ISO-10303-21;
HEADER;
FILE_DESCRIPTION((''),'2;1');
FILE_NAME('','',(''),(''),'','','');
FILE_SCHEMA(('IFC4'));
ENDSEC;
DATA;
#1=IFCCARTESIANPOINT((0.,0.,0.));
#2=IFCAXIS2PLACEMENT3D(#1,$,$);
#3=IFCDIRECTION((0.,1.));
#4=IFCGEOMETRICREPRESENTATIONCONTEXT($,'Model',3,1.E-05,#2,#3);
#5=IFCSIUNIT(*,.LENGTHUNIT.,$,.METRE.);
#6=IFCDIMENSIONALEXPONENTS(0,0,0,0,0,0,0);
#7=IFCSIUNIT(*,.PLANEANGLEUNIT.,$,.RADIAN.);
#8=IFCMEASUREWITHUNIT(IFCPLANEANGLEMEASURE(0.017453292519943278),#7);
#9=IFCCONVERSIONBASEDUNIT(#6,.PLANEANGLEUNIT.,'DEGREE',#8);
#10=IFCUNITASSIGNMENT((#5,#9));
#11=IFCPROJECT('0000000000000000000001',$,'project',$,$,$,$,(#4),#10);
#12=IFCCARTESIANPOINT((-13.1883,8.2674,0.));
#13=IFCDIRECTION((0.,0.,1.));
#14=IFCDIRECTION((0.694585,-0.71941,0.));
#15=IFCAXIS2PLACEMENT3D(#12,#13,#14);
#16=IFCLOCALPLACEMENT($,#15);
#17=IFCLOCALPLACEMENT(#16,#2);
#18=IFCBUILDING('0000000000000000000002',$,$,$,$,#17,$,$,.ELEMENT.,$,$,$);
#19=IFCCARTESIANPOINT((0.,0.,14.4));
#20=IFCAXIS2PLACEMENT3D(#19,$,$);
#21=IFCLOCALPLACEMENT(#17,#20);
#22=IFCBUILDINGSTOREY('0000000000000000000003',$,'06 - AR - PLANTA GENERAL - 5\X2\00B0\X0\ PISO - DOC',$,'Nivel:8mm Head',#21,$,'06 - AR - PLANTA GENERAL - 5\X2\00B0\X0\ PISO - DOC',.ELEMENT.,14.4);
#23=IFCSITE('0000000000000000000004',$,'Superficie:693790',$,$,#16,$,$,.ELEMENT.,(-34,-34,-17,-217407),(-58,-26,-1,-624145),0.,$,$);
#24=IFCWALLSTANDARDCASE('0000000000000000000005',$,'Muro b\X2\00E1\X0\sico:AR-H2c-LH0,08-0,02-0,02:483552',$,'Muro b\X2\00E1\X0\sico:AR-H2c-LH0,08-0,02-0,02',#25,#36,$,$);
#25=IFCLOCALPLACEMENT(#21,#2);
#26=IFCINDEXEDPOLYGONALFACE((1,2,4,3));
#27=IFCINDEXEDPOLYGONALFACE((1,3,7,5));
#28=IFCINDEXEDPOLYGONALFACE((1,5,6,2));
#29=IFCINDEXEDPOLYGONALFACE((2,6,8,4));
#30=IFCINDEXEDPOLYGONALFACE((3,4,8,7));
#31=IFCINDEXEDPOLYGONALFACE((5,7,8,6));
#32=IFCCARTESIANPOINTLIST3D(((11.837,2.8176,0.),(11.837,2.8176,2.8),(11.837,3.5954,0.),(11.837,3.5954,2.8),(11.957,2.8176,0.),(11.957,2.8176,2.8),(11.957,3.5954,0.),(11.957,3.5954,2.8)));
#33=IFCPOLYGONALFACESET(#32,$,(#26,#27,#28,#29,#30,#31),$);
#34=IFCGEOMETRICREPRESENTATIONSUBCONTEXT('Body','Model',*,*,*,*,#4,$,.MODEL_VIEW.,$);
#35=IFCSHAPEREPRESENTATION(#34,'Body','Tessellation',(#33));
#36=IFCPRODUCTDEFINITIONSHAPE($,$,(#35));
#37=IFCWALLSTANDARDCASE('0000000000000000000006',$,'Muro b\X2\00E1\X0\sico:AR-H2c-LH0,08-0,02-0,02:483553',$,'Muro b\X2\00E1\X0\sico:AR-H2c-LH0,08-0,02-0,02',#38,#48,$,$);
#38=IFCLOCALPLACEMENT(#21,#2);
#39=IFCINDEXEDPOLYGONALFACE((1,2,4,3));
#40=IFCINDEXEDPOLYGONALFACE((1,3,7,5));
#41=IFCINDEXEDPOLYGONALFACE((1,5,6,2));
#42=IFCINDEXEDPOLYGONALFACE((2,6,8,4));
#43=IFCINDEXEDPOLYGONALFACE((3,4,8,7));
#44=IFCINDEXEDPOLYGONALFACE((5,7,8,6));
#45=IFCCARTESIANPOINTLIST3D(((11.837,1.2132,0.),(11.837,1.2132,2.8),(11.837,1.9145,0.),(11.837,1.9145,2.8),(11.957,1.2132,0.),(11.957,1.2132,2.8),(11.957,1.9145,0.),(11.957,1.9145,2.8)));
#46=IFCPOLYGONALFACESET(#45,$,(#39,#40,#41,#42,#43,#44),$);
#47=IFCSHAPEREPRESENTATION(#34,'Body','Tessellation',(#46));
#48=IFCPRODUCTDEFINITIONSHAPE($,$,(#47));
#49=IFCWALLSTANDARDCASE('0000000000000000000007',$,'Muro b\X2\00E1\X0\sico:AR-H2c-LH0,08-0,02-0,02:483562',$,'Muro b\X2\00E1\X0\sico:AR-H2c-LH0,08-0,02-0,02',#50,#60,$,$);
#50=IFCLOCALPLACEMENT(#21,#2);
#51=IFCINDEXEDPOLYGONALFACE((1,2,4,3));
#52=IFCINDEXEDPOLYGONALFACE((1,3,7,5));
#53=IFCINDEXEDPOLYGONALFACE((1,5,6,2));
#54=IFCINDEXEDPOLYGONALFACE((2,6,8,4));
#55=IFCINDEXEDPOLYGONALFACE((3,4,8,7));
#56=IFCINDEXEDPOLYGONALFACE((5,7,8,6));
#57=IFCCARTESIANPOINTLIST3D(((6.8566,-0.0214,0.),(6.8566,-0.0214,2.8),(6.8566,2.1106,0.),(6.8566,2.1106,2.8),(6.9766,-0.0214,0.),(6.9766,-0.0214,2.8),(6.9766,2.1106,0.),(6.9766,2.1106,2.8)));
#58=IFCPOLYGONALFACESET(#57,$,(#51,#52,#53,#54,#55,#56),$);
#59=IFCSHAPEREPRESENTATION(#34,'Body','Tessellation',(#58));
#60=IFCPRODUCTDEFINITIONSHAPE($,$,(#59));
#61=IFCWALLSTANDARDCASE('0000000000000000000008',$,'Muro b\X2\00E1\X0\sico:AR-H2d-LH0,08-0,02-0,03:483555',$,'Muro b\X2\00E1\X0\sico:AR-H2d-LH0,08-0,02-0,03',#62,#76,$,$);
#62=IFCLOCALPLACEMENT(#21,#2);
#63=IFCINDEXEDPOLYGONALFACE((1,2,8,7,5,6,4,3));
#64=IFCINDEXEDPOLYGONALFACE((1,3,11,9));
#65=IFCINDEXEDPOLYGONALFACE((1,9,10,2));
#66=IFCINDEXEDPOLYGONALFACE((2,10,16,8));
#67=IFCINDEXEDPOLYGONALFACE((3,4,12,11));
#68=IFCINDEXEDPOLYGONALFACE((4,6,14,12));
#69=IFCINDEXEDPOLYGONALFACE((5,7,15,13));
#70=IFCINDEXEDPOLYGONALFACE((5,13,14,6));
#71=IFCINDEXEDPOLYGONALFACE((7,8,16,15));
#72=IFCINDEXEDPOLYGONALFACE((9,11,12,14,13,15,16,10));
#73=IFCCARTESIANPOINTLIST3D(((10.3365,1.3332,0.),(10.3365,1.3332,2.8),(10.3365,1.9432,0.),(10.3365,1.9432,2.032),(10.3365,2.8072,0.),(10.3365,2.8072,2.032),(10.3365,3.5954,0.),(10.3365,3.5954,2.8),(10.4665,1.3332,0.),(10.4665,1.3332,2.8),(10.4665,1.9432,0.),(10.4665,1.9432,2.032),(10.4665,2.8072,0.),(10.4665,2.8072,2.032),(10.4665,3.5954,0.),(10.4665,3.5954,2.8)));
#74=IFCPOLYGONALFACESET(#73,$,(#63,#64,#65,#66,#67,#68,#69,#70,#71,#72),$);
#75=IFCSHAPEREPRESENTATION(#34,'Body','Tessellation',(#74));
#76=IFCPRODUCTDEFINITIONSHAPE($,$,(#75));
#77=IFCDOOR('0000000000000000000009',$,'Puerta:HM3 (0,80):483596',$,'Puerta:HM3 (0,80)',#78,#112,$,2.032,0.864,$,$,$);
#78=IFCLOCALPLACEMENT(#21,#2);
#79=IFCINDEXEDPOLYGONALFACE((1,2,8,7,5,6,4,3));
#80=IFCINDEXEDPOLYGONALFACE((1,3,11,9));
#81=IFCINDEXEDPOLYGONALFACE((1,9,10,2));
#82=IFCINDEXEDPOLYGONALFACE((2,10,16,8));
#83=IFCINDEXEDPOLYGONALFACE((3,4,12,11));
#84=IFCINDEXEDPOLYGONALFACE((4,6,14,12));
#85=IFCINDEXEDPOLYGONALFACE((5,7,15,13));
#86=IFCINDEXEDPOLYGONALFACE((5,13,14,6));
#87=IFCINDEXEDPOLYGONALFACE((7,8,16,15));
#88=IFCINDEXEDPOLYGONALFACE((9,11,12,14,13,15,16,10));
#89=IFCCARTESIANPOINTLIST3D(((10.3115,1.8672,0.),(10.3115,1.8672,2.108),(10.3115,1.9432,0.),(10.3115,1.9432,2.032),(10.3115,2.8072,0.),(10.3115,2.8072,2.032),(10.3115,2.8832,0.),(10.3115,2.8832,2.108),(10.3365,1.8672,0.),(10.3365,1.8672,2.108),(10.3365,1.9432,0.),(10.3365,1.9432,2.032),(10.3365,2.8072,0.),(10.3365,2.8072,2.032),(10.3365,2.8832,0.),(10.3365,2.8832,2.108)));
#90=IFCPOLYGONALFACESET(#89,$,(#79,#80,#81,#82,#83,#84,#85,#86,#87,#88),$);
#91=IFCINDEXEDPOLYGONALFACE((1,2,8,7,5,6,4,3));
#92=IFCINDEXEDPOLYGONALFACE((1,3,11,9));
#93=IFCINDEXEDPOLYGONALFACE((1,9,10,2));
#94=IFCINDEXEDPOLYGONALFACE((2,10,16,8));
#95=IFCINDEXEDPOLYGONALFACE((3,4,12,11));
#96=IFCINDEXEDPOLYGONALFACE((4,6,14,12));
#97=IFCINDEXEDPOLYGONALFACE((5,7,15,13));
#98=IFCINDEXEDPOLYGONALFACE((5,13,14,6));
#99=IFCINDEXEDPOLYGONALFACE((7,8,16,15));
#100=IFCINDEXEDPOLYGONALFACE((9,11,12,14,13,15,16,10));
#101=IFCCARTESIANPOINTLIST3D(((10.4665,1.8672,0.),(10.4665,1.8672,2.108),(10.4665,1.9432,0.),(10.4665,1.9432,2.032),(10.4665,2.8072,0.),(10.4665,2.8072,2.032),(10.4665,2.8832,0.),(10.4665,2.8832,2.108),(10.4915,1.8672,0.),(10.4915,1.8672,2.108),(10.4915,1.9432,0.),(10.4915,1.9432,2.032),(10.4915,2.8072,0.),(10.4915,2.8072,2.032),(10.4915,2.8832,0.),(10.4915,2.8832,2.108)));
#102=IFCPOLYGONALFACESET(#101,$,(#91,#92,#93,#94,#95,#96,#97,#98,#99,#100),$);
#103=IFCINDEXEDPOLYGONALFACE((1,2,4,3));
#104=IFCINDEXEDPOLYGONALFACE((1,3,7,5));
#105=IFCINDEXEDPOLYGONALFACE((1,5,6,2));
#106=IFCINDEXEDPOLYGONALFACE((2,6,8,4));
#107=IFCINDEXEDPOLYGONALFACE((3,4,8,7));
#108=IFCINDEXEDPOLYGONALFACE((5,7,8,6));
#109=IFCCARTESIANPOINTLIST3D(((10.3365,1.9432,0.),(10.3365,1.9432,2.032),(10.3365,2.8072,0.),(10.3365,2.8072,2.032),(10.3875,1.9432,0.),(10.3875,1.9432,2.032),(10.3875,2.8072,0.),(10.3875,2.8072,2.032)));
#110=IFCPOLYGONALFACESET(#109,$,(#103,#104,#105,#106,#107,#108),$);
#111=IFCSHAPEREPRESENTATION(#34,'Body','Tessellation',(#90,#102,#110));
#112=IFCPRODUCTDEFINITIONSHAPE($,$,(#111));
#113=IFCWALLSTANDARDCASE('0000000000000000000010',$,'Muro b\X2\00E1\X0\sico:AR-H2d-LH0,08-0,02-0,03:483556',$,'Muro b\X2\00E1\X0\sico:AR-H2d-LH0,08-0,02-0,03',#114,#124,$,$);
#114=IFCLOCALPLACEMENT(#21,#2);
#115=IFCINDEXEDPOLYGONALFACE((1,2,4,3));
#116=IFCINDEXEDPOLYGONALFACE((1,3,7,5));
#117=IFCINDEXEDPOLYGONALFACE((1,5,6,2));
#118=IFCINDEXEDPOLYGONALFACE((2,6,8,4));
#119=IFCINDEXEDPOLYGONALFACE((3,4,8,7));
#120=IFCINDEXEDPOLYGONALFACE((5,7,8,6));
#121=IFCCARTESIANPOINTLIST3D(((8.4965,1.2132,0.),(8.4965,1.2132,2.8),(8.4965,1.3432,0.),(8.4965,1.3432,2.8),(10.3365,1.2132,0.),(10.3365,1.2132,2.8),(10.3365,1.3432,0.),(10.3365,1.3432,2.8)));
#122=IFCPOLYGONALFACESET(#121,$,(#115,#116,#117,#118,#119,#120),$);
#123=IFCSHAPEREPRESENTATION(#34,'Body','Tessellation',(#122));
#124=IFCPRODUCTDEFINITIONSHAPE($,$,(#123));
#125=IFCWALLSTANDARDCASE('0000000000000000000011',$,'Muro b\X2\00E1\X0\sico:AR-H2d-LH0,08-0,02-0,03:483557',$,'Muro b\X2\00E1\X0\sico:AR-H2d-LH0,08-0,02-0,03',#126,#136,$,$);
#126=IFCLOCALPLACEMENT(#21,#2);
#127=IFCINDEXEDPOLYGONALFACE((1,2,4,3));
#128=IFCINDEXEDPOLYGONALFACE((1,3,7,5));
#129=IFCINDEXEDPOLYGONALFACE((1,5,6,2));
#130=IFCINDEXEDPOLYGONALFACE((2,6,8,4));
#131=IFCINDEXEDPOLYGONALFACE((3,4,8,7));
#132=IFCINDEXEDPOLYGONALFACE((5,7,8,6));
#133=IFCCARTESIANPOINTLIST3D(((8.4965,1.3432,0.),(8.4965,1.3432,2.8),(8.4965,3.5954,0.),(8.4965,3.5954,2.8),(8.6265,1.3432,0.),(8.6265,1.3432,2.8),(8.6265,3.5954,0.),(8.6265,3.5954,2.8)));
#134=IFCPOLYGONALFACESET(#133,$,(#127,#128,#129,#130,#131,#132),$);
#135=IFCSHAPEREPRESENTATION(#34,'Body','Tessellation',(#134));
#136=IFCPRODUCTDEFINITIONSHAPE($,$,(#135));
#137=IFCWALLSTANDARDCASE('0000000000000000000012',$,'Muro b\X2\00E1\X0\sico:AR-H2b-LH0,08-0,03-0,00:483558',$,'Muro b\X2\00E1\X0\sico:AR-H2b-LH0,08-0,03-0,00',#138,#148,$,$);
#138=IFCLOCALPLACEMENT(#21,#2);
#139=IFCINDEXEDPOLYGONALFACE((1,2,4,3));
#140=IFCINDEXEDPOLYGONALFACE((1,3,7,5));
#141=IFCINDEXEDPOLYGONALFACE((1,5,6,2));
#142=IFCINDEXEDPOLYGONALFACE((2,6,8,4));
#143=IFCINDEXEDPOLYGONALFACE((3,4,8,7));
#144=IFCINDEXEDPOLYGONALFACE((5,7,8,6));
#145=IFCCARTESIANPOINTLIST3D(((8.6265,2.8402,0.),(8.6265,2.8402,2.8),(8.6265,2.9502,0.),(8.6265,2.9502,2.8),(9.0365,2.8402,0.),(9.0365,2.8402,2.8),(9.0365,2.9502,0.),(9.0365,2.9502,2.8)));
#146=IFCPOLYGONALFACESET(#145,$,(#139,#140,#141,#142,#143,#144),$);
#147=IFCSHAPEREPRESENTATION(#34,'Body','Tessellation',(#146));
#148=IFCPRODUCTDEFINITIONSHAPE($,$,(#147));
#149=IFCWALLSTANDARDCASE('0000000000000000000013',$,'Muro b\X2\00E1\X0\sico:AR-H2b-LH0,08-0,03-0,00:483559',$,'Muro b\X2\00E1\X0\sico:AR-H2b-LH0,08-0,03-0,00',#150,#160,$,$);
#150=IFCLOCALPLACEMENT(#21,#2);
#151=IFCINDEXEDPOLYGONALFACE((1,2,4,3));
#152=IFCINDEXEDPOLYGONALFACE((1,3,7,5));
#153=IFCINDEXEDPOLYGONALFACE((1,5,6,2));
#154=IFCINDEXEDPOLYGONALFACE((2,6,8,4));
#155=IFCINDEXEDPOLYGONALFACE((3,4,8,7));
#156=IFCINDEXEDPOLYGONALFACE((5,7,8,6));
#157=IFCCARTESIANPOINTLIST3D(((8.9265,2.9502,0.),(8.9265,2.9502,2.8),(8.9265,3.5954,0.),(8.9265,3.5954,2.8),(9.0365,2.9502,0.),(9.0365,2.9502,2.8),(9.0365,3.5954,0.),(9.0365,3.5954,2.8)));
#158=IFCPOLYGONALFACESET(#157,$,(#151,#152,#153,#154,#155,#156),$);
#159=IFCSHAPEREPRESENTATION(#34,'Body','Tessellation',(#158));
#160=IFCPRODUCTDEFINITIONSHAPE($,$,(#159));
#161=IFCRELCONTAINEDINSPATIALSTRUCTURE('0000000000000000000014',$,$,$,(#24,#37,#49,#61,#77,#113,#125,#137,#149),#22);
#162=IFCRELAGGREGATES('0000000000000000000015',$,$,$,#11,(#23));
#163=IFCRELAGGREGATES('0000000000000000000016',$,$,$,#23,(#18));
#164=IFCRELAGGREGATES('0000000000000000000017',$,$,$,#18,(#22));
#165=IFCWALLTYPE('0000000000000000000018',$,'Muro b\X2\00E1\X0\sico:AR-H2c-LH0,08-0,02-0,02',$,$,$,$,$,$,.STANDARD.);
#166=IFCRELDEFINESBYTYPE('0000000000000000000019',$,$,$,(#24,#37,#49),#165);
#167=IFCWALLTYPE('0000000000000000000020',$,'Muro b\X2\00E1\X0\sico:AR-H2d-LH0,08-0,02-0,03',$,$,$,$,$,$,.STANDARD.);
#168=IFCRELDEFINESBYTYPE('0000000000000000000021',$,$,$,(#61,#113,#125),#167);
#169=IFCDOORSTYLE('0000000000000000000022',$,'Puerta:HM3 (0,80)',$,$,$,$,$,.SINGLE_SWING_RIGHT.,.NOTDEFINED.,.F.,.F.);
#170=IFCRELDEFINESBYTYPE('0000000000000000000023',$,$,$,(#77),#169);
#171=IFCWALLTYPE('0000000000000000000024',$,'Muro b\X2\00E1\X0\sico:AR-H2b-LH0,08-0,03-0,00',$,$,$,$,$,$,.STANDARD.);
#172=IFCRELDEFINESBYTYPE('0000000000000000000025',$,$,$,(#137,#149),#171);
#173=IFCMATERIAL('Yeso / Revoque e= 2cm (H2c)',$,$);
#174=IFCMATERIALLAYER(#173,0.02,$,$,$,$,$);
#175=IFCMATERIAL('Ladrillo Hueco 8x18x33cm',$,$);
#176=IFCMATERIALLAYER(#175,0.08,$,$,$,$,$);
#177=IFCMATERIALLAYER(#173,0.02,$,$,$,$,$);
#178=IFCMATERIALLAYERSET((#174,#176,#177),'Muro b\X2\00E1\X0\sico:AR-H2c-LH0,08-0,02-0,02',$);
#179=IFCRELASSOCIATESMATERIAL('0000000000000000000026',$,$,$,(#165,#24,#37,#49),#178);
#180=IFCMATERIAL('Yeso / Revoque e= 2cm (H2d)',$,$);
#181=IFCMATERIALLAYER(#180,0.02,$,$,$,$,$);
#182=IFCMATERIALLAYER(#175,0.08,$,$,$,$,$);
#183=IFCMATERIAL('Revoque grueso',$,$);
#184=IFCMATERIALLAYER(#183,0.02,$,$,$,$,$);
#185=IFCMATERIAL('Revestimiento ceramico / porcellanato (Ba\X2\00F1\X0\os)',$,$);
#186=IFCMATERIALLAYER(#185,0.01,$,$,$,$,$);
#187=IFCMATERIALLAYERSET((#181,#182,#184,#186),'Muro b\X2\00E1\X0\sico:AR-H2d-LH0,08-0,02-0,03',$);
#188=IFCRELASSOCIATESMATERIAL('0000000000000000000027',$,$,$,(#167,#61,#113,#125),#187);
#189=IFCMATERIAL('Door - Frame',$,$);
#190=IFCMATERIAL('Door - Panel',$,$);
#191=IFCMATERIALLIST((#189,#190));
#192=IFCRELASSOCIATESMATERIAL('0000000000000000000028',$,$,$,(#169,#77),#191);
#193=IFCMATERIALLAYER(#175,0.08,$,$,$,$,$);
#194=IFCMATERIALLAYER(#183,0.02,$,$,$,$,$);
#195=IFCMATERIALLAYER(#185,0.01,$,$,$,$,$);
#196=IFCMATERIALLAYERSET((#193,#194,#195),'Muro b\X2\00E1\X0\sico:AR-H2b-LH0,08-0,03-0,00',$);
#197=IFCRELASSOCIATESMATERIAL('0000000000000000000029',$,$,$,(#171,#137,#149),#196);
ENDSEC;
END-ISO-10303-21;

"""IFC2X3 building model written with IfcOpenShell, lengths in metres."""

from ifc_helpers import new_model, entity, si_unit, converted_unit, direction, frame, frame_2d, origin, place, context, subcontext, project, spatial, polyline, rectangle, outline, extrude, source, transform, mapped, material, material_list, layer, layer_set, layer_usage, type_object, type_shapes, element, fill, save


model = new_model("IFC2X3")

# Units and contexts
model_context = context("Model", 3, precision=1e-05, world=origin(), true_north=direction((0.0, 1.0)))
body_context = subcontext(model_context, "Body", "Model", "MODEL_VIEW")
ifc_project = project(units=[si_unit("LENGTHUNIT", "METRE"), converted_unit("PLANEANGLEUNIT", "DEGREE", entity("IfcPlaneAngleMeasure", 0.017453292519943278), si_unit("PLANEANGLEUNIT", "RADIAN"), dimensions=[0, 0, 0, 0, 0, 0, 0])], contexts=[model_context])

# Site, building, storey
site_placement = place(None, frame((-13.1883, 8.2674, 0.0), z_axis=(0.0, 0.0, 1.0), x_axis=(0.694585, -0.71941, 0.0)))
site = spatial("IfcSite", under=ifc_project, at=site_placement, Name="Superficie:693790", CompositionType="ELEMENT", RefLatitude=(-34, -34, -17, -217407), RefLongitude=(-58, -26, -1, -624145), RefElevation=0.0)
building_placement = place(site_placement, origin())
building = spatial("IfcBuilding", under=site, at=building_placement, CompositionType="ELEMENT")
storey_placement = place(building_placement, frame((0.0, 0.0, 14.4)))
storey = spatial("IfcBuildingStorey", under=building, at=storey_placement, Name="06 - AR - PLANTA GENERAL - 5° PISO - DOC", ObjectType="Nivel:8mm Head", LongName="06 - AR - PLANTA GENERAL - 5° PISO - DOC", CompositionType="ELEMENT", Elevation=14.4)

# Walls
ifc_material_1 = material(Name="Yeso / Revoque e= 2cm (H2c)")
ifc_layer_1 = layer(ifc_material_1, 0.02)
ifc_material_2 = material(Name="Ladrillo Hueco 8x18x33cm")
ifc_layer_2 = layer(ifc_material_2, 0.08)
ifc_layer_3 = layer(ifc_material_1, 0.02)
ifc_layer_set_1 = layer_set([ifc_layer_1, ifc_layer_2, ifc_layer_3], Name="Muro básico:AR-H2c-LH0,08-0,02-0,02")
ifc_layer_usage_1 = layer_usage(ifc_layer_set_1, "AXIS2", "NEGATIVE", 0.06)
wall_type_1 = type_object("IfcWallType", Name="Muro básico:AR-H2c-LH0,08-0,02-0,02", PredefinedType="STANDARD", material=ifc_layer_set_1)
wall_1_placement = place(storey_placement, frame((11.897, 3.5954, 0.0), z_axis=(0.0, 0.0, 1.0), x_axis=(0.0, -1.0, 0.0)))
element("IfcWallStandardCase", 1, at=wall_1_placement, inside=storey, type_object=wall_type_1, material=ifc_layer_usage_1, Name="Muro básico:AR-H2c-LH0,08-0,02-0,02:483552", ObjectType="Muro básico:AR-H2c-LH0,08-0,02-0,02", context=body_context, shape_type="SweptSolid", body=[
    extrude(rectangle(XDim=0.7779, YDim=0.12, at=frame_2d((0.3889, 0.0), x_axis=(-1.0, 0.0))), origin(), (0.0, 0.0, 1.0), 2.8),
])
ifc_layer_usage_2 = layer_usage(ifc_layer_set_1, "AXIS2", "NEGATIVE", 0.06)
wall_2_placement = place(storey_placement, frame((11.897, 1.9145, 0.0), z_axis=(0.0, 0.0, 1.0), x_axis=(0.0, -1.0, 0.0)))
element("IfcWallStandardCase", 2, at=wall_2_placement, inside=storey, type_object=wall_type_1, material=ifc_layer_usage_2, Name="Muro básico:AR-H2c-LH0,08-0,02-0,02:483553", ObjectType="Muro básico:AR-H2c-LH0,08-0,02-0,02", context=body_context, shape_type="SweptSolid", body=[
    extrude(rectangle(XDim=0.7014, YDim=0.12, at=frame_2d((0.3507, 0.0), x_axis=(-1.0, 0.0))), origin(), (0.0, 0.0, 1.0), 2.8),
])
ifc_layer_usage_3 = layer_usage(ifc_layer_set_1, "AXIS2", "NEGATIVE", 0.06)
wall_3_placement = place(storey_placement, frame((6.9166, 2.1106, 0.0), z_axis=(0.0, 0.0, 1.0), x_axis=(0.0, -1.0, 0.0)))
element("IfcWallStandardCase", 3, at=wall_3_placement, inside=storey, type_object=wall_type_1, material=ifc_layer_usage_3, Name="Muro básico:AR-H2c-LH0,08-0,02-0,02:483562", ObjectType="Muro básico:AR-H2c-LH0,08-0,02-0,02", context=body_context, shape_type="SweptSolid", body=[
    extrude(rectangle(XDim=2.132, YDim=0.12, at=frame_2d((1.066, 0.0), x_axis=(-1.0, 0.0))), origin(), (0.0, 0.0, 1.0), 2.8),
])

# Wall, opening, door
ifc_material_3 = material(Name="Yeso / Revoque e= 2cm (H2d)")
ifc_layer_4 = layer(ifc_material_3, 0.02)
ifc_layer_5 = layer(ifc_material_2, 0.08)
ifc_material_4 = material(Name="Revoque grueso")
ifc_layer_6 = layer(ifc_material_4, 0.02)
ifc_material_5 = material(Name="Revestimiento ceramico / porcellanato (Baños)")
ifc_layer_7 = layer(ifc_material_5, 0.01)
ifc_layer_set_2 = layer_set([ifc_layer_4, ifc_layer_5, ifc_layer_6, ifc_layer_7], Name="Muro básico:AR-H2d-LH0,08-0,02-0,03")
ifc_layer_usage_4 = layer_usage(ifc_layer_set_2, "AXIS2", "POSITIVE", -0.065)
wall_type_2 = type_object("IfcWallType", Name="Muro básico:AR-H2d-LH0,08-0,02-0,03", PredefinedType="STANDARD", material=ifc_layer_set_2)
wall_4_placement = place(storey_placement, frame((10.4015, 1.3332, 0.0), z_axis=(0.0, 0.0, 1.0), x_axis=(0.0, 1.0, 0.0)))
wall_4 = element("IfcWallStandardCase", 4, at=wall_4_placement, inside=storey, type_object=wall_type_2, material=ifc_layer_usage_4, Name="Muro básico:AR-H2d-LH0,08-0,02-0,03:483555", ObjectType="Muro básico:AR-H2d-LH0,08-0,02-0,03", context=body_context, shape_type="SweptSolid", body=[
    extrude(rectangle(XDim=2.2623, YDim=0.13, at=frame_2d((1.1311, 0.0), x_axis=(-1.0, 0.0))), origin(), (0.0, 0.0, 1.0), 2.8),
])
opening_1_placement = place(wall_4_placement, frame((0.61, -0.065, 0.0)))
opening_1 = element("IfcOpeningElement", 5, at=opening_1_placement, cuts=wall_4, ObjectType="Opening", context=body_context, shape_type="SweptSolid", body=[
    extrude(rectangle(XDim=0.864, YDim=2.032, at=frame_2d((1.016, 0.432), x_axis=(0.0, 1.0))), frame((0.0, 0.0, 0.0), z_axis=(0.0, 1.0, 0.0), x_axis=(0.0, 0.0, 1.0)), (0.0, 0.0, 1.0), 0.13),
])
ifc_material_6 = material(Name="Door - Frame")
ifc_material_7 = material(Name="Door - Panel")
ifc_material_list = material_list([ifc_material_6, ifc_material_7])
door_style_1 = type_object("IfcDoorStyle", Name="Puerta:HM3 (0,80)", ConstructionType="NOTDEFINED", OperationType="SINGLE_SWING_RIGHT", ParameterTakesPrecedence=False, Sizeable=False, material=ifc_material_list)
shared_shape_1 = source(origin(), body_context, "Body", "SweptSolid", [
    extrude(outline(polyline([(-0.508, -1.073), (0.508, -1.073), (0.508, 1.035), (0.432, 1.035), (0.432, -0.997), (-0.432, -0.997), (-0.432, 1.035), (-0.508, 1.035), (-0.508, -1.073)])), frame((0.432, 0.13, 1.035), z_axis=(0.0, 1.0, 0.0), x_axis=(1.0, 0.0, 0.0)), (0.0, 0.0, 1.0), 0.025),
    extrude(outline(polyline([(-1.073, -0.508), (1.035, -0.508), (1.035, -0.432), (-0.997, -0.432), (-0.997, 0.432), (1.035, 0.432), (1.035, 0.508), (-1.073, 0.508), (-1.073, -0.508)])), frame((0.432, -0.025, 1.035), z_axis=(0.0, 1.0, 0.0), x_axis=(0.0, 0.0, -1.0)), (0.0, 0.0, 1.0), 0.025),
    extrude(rectangle(XDim=0.051, YDim=0.864, at=frame_2d((0.0, 0.0), x_axis=(1.0, 0.0))), frame((0.432, 0.1045, 0.0), z_axis=(0.0, 0.0, 1.0), x_axis=(0.0, 1.0, 0.0)), (0.0, 0.0, 1.0), 2.032),
])
type_shapes(door_style_1, [shared_shape_1])
door_1_placement = place(opening_1_placement, origin())
door_1 = element("IfcDoor", 6, at=door_1_placement, inside=storey, type_object=door_style_1, material=ifc_material_list, Name="Puerta:HM3 (0,80):483596", ObjectType="Puerta:HM3 (0,80)", OverallHeight=2.032, OverallWidth=0.864, context=body_context, shape_type="MappedRepresentation", body=[
    mapped(shared_shape_1, transform((0.0, 0.0, 0.0), scale=1.0)),
])
fill(opening_1, door_1)

# Walls
ifc_layer_usage_5 = layer_usage(ifc_layer_set_2, "AXIS2", "NEGATIVE", 0.065)
wall_5_placement = place(storey_placement, frame((10.3365, 1.2782, 0.0), z_axis=(0.0, 0.0, 1.0), x_axis=(-1.0, 0.0, 0.0)))
element("IfcWallStandardCase", 7, at=wall_5_placement, inside=storey, type_object=wall_type_2, material=ifc_layer_usage_5, Name="Muro básico:AR-H2d-LH0,08-0,02-0,03:483556", ObjectType="Muro básico:AR-H2d-LH0,08-0,02-0,03", context=body_context, shape_type="SweptSolid", body=[
    extrude(rectangle(XDim=1.84, YDim=0.13, at=frame_2d((0.92, 0.0), x_axis=(-1.0, 0.0))), origin(), (0.0, 0.0, 1.0), 2.8),
])
ifc_layer_usage_6 = layer_usage(ifc_layer_set_2, "AXIS2", "NEGATIVE", 0.065)
wall_6_placement = place(storey_placement, frame((8.5615, 1.3432, 0.0), z_axis=(0.0, 0.0, 1.0), x_axis=(0.0, 1.0, 0.0)))
element("IfcWallStandardCase", 8, at=wall_6_placement, inside=storey, type_object=wall_type_2, material=ifc_layer_usage_6, Name="Muro básico:AR-H2d-LH0,08-0,02-0,03:483557", ObjectType="Muro básico:AR-H2d-LH0,08-0,02-0,03", context=body_context, shape_type="SweptSolid", body=[
    extrude(rectangle(XDim=2.2523, YDim=0.13, at=frame_2d((1.1261, 0.0), x_axis=(-1.0, 0.0))), origin(), (0.0, 0.0, 1.0), 2.8),
])
ifc_layer_8 = layer(ifc_material_2, 0.08)
ifc_layer_9 = layer(ifc_material_4, 0.02)
ifc_layer_10 = layer(ifc_material_5, 0.01)
ifc_layer_set_3 = layer_set([ifc_layer_8, ifc_layer_9, ifc_layer_10], Name="Muro básico:AR-H2b-LH0,08-0,03-0,00")
ifc_layer_usage_7 = layer_usage(ifc_layer_set_3, "AXIS2", "NEGATIVE", 0.055)
wall_type_3 = type_object("IfcWallType", Name="Muro básico:AR-H2b-LH0,08-0,03-0,00", PredefinedType="STANDARD", material=ifc_layer_set_3)
wall_7_placement = place(storey_placement, frame((8.6265, 2.8952, 0.0)))
element("IfcWallStandardCase", 9, at=wall_7_placement, inside=storey, type_object=wall_type_3, material=ifc_layer_usage_7, Name="Muro básico:AR-H2b-LH0,08-0,03-0,00:483558", ObjectType="Muro básico:AR-H2b-LH0,08-0,03-0,00", context=body_context, shape_type="SweptSolid", body=[
    extrude(rectangle(XDim=0.41, YDim=0.11, at=frame_2d((0.205, 0.0), x_axis=(-1.0, 0.0))), origin(), (0.0, 0.0, 1.0), 2.8),
])
ifc_layer_usage_8 = layer_usage(ifc_layer_set_3, "AXIS2", "NEGATIVE", 0.055)
wall_8_placement = place(storey_placement, frame((8.9815, 2.9502, 0.0), z_axis=(0.0, 0.0, 1.0), x_axis=(0.0, 1.0, 0.0)))
element("IfcWallStandardCase", 10, at=wall_8_placement, inside=storey, type_object=wall_type_3, material=ifc_layer_usage_8, Name="Muro básico:AR-H2b-LH0,08-0,03-0,00:483559", ObjectType="Muro básico:AR-H2b-LH0,08-0,03-0,00", context=body_context, shape_type="SweptSolid", body=[
    extrude(rectangle(XDim=0.6453, YDim=0.11, at=frame_2d((0.3226, 0.0), x_axis=(-1.0, 0.0))), origin(), (0.0, 0.0, 1.0), 2.8),
])

save(model, "model.ifc")
